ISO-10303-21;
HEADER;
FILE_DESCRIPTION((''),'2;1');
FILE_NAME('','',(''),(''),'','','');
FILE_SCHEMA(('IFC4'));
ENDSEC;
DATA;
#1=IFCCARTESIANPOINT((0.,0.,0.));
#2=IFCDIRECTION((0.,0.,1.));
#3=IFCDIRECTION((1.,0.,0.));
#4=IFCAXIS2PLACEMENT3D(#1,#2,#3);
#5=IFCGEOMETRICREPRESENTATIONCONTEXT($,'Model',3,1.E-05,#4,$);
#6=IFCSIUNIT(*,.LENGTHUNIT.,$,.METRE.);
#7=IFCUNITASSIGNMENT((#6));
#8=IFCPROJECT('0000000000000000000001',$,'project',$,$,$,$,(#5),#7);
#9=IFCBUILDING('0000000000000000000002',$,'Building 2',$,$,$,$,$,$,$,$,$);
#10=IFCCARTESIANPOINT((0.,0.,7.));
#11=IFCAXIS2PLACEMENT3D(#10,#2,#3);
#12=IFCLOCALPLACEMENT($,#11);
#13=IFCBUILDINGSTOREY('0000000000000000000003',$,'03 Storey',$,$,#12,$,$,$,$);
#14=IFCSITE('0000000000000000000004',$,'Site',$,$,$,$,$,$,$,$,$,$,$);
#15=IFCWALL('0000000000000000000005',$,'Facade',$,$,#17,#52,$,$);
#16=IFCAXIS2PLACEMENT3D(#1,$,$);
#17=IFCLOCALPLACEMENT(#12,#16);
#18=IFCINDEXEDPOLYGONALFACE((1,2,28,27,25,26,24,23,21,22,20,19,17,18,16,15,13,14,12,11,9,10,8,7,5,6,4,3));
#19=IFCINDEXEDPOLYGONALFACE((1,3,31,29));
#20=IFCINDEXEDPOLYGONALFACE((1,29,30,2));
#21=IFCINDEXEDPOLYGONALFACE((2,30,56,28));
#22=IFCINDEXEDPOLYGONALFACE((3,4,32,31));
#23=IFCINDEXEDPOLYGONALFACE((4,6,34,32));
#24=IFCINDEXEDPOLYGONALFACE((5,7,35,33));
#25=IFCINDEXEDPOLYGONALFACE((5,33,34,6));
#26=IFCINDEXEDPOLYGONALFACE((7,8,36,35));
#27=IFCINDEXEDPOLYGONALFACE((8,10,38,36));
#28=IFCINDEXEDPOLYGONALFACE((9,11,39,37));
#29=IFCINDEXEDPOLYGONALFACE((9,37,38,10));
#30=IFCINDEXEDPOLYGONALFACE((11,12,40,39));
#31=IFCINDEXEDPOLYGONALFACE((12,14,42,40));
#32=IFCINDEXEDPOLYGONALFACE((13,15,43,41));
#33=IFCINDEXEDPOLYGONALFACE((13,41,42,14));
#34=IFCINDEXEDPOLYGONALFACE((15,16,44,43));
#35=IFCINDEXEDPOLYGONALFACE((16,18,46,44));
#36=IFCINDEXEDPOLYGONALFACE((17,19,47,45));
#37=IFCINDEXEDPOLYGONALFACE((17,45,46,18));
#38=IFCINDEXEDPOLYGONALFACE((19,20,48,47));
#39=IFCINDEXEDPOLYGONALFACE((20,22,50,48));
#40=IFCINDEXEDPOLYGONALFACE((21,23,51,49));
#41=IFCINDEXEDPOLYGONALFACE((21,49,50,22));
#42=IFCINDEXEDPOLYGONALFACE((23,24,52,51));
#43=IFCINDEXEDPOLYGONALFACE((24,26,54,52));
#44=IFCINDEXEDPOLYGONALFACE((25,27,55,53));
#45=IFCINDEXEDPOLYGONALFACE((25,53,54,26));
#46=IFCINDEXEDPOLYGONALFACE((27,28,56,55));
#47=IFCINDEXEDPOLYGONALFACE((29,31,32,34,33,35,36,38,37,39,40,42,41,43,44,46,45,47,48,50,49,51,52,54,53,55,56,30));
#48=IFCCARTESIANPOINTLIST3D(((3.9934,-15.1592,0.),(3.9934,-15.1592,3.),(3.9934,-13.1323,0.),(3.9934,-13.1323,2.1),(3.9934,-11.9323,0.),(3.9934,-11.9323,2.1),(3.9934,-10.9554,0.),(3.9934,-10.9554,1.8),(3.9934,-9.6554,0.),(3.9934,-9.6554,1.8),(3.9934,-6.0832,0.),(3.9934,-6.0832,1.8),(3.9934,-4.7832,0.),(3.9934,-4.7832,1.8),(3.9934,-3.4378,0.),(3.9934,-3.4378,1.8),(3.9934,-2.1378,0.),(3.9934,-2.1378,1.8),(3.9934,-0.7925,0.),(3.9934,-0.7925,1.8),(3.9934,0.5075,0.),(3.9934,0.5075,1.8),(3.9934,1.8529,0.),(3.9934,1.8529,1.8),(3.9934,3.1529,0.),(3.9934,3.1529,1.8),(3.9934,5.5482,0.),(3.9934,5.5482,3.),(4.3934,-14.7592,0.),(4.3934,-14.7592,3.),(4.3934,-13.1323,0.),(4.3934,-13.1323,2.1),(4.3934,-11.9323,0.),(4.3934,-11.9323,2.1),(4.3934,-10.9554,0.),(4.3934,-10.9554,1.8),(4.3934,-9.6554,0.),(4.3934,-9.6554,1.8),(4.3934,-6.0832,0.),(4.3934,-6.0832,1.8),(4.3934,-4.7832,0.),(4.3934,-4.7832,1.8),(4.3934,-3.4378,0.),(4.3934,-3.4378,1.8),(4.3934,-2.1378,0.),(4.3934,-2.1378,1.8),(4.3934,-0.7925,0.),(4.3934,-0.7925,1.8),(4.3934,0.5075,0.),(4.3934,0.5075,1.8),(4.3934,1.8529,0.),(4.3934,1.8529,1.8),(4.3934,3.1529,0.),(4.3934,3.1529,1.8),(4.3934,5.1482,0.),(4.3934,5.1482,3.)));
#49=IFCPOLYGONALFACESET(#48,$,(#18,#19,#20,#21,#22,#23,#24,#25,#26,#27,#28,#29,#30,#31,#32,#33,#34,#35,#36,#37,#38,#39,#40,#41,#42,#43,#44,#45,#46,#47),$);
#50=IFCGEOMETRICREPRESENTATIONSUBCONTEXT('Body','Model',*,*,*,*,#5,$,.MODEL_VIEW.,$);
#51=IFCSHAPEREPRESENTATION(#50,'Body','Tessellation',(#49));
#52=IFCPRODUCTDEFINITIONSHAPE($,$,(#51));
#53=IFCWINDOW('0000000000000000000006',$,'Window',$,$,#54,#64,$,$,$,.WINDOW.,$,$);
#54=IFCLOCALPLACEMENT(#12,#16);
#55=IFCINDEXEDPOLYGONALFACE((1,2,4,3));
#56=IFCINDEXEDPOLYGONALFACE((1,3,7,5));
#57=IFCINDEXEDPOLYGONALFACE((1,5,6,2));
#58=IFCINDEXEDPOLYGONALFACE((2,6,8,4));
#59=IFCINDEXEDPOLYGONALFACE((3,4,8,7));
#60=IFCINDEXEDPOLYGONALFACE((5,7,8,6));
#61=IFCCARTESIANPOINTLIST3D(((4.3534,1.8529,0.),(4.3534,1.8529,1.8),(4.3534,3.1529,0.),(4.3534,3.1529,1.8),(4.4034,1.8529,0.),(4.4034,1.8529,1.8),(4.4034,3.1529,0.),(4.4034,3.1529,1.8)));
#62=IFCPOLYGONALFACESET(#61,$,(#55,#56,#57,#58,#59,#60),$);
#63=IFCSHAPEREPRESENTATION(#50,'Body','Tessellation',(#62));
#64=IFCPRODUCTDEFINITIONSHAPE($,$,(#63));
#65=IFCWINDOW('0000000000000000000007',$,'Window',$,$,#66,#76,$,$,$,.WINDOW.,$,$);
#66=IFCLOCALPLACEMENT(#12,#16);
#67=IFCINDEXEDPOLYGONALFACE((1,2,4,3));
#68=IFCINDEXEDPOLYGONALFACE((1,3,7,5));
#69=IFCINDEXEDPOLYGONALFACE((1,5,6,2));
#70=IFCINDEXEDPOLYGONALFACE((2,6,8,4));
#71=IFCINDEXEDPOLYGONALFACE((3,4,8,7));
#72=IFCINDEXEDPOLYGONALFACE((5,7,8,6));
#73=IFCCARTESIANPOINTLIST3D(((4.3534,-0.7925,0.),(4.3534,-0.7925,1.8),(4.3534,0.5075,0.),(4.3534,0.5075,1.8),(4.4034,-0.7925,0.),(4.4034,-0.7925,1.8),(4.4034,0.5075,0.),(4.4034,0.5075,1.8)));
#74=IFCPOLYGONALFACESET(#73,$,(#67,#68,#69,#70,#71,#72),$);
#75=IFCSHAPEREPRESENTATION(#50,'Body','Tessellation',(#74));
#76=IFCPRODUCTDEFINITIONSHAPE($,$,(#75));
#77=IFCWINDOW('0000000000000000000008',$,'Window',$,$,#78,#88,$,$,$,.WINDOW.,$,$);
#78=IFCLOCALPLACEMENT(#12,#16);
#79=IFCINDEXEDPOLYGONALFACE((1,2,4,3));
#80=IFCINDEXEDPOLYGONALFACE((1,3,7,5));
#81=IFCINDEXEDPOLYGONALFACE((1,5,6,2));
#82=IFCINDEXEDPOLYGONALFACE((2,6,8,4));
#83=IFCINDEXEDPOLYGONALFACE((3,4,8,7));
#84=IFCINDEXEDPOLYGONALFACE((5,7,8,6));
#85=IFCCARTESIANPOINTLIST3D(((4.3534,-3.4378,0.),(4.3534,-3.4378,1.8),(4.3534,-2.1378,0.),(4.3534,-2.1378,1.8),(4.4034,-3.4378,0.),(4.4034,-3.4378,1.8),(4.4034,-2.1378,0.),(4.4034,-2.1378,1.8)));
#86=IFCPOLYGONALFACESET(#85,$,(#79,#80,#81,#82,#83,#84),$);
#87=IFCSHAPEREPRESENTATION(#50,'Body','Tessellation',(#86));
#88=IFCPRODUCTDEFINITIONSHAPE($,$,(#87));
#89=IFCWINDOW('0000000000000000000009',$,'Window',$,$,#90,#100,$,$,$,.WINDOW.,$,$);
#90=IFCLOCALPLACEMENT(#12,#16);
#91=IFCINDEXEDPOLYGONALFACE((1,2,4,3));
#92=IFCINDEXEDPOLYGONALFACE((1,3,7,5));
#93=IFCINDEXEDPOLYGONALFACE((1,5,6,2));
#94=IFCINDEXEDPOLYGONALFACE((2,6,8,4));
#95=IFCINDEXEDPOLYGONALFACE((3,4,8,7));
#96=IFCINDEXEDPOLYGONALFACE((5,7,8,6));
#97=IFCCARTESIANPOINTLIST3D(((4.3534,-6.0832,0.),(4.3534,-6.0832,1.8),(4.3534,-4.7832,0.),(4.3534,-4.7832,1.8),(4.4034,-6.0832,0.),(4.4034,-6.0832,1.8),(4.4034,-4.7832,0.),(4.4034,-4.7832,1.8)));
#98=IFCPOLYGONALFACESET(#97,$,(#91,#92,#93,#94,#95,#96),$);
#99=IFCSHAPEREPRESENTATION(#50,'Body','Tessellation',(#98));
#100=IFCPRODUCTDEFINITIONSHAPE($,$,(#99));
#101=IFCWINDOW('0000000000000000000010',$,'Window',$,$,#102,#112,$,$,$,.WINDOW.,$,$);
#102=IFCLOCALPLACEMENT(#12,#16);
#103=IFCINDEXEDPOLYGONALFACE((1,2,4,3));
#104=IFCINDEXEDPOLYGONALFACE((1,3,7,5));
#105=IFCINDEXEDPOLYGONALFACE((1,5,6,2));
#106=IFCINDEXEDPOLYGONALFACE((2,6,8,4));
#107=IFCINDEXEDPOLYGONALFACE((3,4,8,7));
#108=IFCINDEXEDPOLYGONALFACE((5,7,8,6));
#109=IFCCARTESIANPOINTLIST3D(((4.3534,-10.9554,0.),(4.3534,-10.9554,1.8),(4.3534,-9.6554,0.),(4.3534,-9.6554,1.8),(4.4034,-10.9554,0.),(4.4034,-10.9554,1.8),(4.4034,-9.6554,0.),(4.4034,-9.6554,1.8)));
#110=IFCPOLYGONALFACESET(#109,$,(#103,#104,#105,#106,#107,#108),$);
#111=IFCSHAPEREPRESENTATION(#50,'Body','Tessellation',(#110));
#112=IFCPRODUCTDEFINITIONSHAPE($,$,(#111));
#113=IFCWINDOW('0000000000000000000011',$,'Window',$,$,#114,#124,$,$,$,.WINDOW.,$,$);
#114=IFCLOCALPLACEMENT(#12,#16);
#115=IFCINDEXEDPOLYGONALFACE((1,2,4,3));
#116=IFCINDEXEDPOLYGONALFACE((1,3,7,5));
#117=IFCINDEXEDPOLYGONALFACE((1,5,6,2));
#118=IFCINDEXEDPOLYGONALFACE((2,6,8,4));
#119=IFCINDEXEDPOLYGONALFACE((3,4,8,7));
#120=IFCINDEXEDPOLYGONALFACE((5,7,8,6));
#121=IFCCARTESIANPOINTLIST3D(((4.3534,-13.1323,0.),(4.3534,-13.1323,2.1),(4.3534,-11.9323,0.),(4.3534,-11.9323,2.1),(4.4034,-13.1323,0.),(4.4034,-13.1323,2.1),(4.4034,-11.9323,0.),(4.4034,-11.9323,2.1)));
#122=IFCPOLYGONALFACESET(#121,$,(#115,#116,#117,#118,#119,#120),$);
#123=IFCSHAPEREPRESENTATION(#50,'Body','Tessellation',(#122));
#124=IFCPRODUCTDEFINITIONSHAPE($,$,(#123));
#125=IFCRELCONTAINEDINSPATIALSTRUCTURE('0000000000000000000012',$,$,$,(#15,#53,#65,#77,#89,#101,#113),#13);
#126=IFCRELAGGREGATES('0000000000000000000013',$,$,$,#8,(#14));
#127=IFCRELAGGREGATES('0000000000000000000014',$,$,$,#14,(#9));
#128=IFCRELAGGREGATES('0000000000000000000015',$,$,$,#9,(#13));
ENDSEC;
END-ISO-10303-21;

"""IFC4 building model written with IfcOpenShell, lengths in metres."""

from ifc_helpers import new_model, si_unit, frame, origin_with_axes, place, context, subcontext, project, spatial, line, indexed_curve, outline, extrude, element, fill, save


model = new_model("IFC4")

# Units and contexts
model_context = context("Model", 3, precision=1e-05, world=origin_with_axes())
body_context = subcontext(model_context, "Body", "Model", "MODEL_VIEW")
ifc_project = project(units=[si_unit("LENGTHUNIT", "METRE")], contexts=[model_context])

# Site, building, storey
site = spatial("IfcSite", under=ifc_project, Name="Site")
building = spatial("IfcBuilding", under=site, Name="Building 2")
storey_placement = place(None, frame((0.0, 0.0, 7.0), z_axis=(0.0, 0.0, 1.0), x_axis=(1.0, 0.0, 0.0)))
storey = spatial("IfcBuildingStorey", under=building, at=storey_placement, Name="03 Storey")

# Wall, openings, windows
wall_1_placement = place(storey_placement, origin_with_axes())
wall_1 = element("IfcWall", 1, at=wall_1_placement, inside=storey, Name="Facade", context=body_context, shape_type="SweptSolid", body=[
    extrude(outline(indexed_curve([(4.3934, 5.1482), (4.3934, -14.7592), (3.9934, -15.1592), (3.9934, 5.5482)], segments=[line(1, 2), line(2, 3), line(3, 4)])), origin_with_axes(), (0.0, 0.0, 1.0), 3.0),
])
opening_1_placement = place(wall_1_placement, origin_with_axes())
opening_1 = element("IfcOpeningElement", 2, at=opening_1_placement, cuts=wall_1, context=body_context, shape_type="SweptSolid", body=[
    extrude(outline(indexed_curve([(3.9534, 3.1529), (4.4534, 3.1529), (4.4534, 1.8529), (3.9534, 1.8529)], segments=[line(1, 2), line(2, 3), line(3, 4)])), origin_with_axes(), (0.0, 0.0, 1.0), 1.8),
])
opening_2_placement = place(wall_1_placement, origin_with_axes())
opening_2 = element("IfcOpeningElement", 3, at=opening_2_placement, cuts=wall_1, context=body_context, shape_type="SweptSolid", body=[
    extrude(outline(indexed_curve([(3.9534, 0.5075), (4.4534, 0.5075), (4.4534, -0.7925), (3.9534, -0.7925)], segments=[line(1, 2), line(2, 3), line(3, 4)])), origin_with_axes(), (0.0, 0.0, 1.0), 1.8),
])
opening_3_placement = place(wall_1_placement, origin_with_axes())
opening_3 = element("IfcOpeningElement", 4, at=opening_3_placement, cuts=wall_1, context=body_context, shape_type="SweptSolid", body=[
    extrude(outline(indexed_curve([(3.9534, -2.1378), (4.4534, -2.1378), (4.4534, -3.4378), (3.9534, -3.4378)], segments=[line(1, 2), line(2, 3), line(3, 4)])), origin_with_axes(), (0.0, 0.0, 1.0), 1.8),
])
opening_4_placement = place(wall_1_placement, origin_with_axes())
opening_4 = element("IfcOpeningElement", 5, at=opening_4_placement, cuts=wall_1, context=body_context, shape_type="SweptSolid", body=[
    extrude(outline(indexed_curve([(3.9534, -4.7832), (4.4534, -4.7832), (4.4534, -6.0832), (3.9534, -6.0832)], segments=[line(1, 2), line(2, 3), line(3, 4)])), origin_with_axes(), (0.0, 0.0, 1.0), 1.8),
])
opening_5_placement = place(wall_1_placement, origin_with_axes())
opening_5 = element("IfcOpeningElement", 6, at=opening_5_placement, cuts=wall_1, context=body_context, shape_type="SweptSolid", body=[
    extrude(outline(indexed_curve([(3.9534, -9.6554), (4.4534, -9.6554), (4.4534, -10.9554), (3.9534, -10.9554)], segments=[line(1, 2), line(2, 3), line(3, 4)])), origin_with_axes(), (0.0, 0.0, 1.0), 1.8),
])
opening_6_placement = place(wall_1_placement, origin_with_axes())
opening_6 = element("IfcOpeningElement", 7, at=opening_6_placement, cuts=wall_1, context=body_context, shape_type="SweptSolid", body=[
    extrude(outline(indexed_curve([(3.9534, -11.9323), (4.4534, -11.9323), (4.4534, -13.1323), (3.9534, -13.1323)], segments=[line(1, 2), line(2, 3), line(3, 4)])), origin_with_axes(), (0.0, 0.0, 1.0), 2.1),
])
window_1_placement = place(storey_placement, origin_with_axes())
window_1 = element("IfcWindow", 8, at=window_1_placement, inside=storey, Name="Window", PredefinedType="WINDOW", context=body_context, shape_type="SweptSolid", body=[
    extrude(outline(indexed_curve([(4.3534, 3.1529), (4.4034, 3.1529), (4.4034, 1.8529), (4.3534, 1.8529)], segments=[line(1, 2), line(2, 3), line(3, 4)])), origin_with_axes(), (0.0, 0.0, 1.0), 1.8),
])
fill(opening_1, window_1)
window_2_placement = place(storey_placement, origin_with_axes())
window_2 = element("IfcWindow", 9, at=window_2_placement, inside=storey, Name="Window", PredefinedType="WINDOW", context=body_context, shape_type="SweptSolid", body=[
    extrude(outline(indexed_curve([(4.3534, 0.5075), (4.4034, 0.5075), (4.4034, -0.7925), (4.3534, -0.7925)], segments=[line(1, 2), line(2, 3), line(3, 4)])), origin_with_axes(), (0.0, 0.0, 1.0), 1.8),
])
fill(opening_2, window_2)
window_3_placement = place(storey_placement, origin_with_axes())
window_3 = element("IfcWindow", 10, at=window_3_placement, inside=storey, Name="Window", PredefinedType="WINDOW", context=body_context, shape_type="SweptSolid", body=[
    extrude(outline(indexed_curve([(4.3534, -2.1378), (4.4034, -2.1378), (4.4034, -3.4378), (4.3534, -3.4378)], segments=[line(1, 2), line(2, 3), line(3, 4)])), origin_with_axes(), (0.0, 0.0, 1.0), 1.8),
])
fill(opening_3, window_3)
window_4_placement = place(storey_placement, origin_with_axes())
window_4 = element("IfcWindow", 11, at=window_4_placement, inside=storey, Name="Window", PredefinedType="WINDOW", context=body_context, shape_type="SweptSolid", body=[
    extrude(outline(indexed_curve([(4.3534, -4.7832), (4.4034, -4.7832), (4.4034, -6.0832), (4.3534, -6.0832)], segments=[line(1, 2), line(2, 3), line(3, 4)])), origin_with_axes(), (0.0, 0.0, 1.0), 1.8),
])
fill(opening_4, window_4)
window_5_placement = place(storey_placement, origin_with_axes())
window_5 = element("IfcWindow", 12, at=window_5_placement, inside=storey, Name="Window", PredefinedType="WINDOW", context=body_context, shape_type="SweptSolid", body=[
    extrude(outline(indexed_curve([(4.3534, -9.6554), (4.4034, -9.6554), (4.4034, -10.9554), (4.3534, -10.9554)], segments=[line(1, 2), line(2, 3), line(3, 4)])), origin_with_axes(), (0.0, 0.0, 1.0), 1.8),
])
fill(opening_5, window_5)
window_6_placement = place(storey_placement, origin_with_axes())
window_6 = element("IfcWindow", 13, at=window_6_placement, inside=storey, Name="Window", PredefinedType="WINDOW", context=body_context, shape_type="SweptSolid", body=[
    extrude(outline(indexed_curve([(4.3534, -11.9323), (4.4034, -11.9323), (4.4034, -13.1323), (4.3534, -13.1323)], segments=[line(1, 2), line(2, 3), line(3, 4)])), origin_with_axes(), (0.0, 0.0, 1.0), 2.1),
])
fill(opening_6, window_6)

save(model, "model.ifc")
